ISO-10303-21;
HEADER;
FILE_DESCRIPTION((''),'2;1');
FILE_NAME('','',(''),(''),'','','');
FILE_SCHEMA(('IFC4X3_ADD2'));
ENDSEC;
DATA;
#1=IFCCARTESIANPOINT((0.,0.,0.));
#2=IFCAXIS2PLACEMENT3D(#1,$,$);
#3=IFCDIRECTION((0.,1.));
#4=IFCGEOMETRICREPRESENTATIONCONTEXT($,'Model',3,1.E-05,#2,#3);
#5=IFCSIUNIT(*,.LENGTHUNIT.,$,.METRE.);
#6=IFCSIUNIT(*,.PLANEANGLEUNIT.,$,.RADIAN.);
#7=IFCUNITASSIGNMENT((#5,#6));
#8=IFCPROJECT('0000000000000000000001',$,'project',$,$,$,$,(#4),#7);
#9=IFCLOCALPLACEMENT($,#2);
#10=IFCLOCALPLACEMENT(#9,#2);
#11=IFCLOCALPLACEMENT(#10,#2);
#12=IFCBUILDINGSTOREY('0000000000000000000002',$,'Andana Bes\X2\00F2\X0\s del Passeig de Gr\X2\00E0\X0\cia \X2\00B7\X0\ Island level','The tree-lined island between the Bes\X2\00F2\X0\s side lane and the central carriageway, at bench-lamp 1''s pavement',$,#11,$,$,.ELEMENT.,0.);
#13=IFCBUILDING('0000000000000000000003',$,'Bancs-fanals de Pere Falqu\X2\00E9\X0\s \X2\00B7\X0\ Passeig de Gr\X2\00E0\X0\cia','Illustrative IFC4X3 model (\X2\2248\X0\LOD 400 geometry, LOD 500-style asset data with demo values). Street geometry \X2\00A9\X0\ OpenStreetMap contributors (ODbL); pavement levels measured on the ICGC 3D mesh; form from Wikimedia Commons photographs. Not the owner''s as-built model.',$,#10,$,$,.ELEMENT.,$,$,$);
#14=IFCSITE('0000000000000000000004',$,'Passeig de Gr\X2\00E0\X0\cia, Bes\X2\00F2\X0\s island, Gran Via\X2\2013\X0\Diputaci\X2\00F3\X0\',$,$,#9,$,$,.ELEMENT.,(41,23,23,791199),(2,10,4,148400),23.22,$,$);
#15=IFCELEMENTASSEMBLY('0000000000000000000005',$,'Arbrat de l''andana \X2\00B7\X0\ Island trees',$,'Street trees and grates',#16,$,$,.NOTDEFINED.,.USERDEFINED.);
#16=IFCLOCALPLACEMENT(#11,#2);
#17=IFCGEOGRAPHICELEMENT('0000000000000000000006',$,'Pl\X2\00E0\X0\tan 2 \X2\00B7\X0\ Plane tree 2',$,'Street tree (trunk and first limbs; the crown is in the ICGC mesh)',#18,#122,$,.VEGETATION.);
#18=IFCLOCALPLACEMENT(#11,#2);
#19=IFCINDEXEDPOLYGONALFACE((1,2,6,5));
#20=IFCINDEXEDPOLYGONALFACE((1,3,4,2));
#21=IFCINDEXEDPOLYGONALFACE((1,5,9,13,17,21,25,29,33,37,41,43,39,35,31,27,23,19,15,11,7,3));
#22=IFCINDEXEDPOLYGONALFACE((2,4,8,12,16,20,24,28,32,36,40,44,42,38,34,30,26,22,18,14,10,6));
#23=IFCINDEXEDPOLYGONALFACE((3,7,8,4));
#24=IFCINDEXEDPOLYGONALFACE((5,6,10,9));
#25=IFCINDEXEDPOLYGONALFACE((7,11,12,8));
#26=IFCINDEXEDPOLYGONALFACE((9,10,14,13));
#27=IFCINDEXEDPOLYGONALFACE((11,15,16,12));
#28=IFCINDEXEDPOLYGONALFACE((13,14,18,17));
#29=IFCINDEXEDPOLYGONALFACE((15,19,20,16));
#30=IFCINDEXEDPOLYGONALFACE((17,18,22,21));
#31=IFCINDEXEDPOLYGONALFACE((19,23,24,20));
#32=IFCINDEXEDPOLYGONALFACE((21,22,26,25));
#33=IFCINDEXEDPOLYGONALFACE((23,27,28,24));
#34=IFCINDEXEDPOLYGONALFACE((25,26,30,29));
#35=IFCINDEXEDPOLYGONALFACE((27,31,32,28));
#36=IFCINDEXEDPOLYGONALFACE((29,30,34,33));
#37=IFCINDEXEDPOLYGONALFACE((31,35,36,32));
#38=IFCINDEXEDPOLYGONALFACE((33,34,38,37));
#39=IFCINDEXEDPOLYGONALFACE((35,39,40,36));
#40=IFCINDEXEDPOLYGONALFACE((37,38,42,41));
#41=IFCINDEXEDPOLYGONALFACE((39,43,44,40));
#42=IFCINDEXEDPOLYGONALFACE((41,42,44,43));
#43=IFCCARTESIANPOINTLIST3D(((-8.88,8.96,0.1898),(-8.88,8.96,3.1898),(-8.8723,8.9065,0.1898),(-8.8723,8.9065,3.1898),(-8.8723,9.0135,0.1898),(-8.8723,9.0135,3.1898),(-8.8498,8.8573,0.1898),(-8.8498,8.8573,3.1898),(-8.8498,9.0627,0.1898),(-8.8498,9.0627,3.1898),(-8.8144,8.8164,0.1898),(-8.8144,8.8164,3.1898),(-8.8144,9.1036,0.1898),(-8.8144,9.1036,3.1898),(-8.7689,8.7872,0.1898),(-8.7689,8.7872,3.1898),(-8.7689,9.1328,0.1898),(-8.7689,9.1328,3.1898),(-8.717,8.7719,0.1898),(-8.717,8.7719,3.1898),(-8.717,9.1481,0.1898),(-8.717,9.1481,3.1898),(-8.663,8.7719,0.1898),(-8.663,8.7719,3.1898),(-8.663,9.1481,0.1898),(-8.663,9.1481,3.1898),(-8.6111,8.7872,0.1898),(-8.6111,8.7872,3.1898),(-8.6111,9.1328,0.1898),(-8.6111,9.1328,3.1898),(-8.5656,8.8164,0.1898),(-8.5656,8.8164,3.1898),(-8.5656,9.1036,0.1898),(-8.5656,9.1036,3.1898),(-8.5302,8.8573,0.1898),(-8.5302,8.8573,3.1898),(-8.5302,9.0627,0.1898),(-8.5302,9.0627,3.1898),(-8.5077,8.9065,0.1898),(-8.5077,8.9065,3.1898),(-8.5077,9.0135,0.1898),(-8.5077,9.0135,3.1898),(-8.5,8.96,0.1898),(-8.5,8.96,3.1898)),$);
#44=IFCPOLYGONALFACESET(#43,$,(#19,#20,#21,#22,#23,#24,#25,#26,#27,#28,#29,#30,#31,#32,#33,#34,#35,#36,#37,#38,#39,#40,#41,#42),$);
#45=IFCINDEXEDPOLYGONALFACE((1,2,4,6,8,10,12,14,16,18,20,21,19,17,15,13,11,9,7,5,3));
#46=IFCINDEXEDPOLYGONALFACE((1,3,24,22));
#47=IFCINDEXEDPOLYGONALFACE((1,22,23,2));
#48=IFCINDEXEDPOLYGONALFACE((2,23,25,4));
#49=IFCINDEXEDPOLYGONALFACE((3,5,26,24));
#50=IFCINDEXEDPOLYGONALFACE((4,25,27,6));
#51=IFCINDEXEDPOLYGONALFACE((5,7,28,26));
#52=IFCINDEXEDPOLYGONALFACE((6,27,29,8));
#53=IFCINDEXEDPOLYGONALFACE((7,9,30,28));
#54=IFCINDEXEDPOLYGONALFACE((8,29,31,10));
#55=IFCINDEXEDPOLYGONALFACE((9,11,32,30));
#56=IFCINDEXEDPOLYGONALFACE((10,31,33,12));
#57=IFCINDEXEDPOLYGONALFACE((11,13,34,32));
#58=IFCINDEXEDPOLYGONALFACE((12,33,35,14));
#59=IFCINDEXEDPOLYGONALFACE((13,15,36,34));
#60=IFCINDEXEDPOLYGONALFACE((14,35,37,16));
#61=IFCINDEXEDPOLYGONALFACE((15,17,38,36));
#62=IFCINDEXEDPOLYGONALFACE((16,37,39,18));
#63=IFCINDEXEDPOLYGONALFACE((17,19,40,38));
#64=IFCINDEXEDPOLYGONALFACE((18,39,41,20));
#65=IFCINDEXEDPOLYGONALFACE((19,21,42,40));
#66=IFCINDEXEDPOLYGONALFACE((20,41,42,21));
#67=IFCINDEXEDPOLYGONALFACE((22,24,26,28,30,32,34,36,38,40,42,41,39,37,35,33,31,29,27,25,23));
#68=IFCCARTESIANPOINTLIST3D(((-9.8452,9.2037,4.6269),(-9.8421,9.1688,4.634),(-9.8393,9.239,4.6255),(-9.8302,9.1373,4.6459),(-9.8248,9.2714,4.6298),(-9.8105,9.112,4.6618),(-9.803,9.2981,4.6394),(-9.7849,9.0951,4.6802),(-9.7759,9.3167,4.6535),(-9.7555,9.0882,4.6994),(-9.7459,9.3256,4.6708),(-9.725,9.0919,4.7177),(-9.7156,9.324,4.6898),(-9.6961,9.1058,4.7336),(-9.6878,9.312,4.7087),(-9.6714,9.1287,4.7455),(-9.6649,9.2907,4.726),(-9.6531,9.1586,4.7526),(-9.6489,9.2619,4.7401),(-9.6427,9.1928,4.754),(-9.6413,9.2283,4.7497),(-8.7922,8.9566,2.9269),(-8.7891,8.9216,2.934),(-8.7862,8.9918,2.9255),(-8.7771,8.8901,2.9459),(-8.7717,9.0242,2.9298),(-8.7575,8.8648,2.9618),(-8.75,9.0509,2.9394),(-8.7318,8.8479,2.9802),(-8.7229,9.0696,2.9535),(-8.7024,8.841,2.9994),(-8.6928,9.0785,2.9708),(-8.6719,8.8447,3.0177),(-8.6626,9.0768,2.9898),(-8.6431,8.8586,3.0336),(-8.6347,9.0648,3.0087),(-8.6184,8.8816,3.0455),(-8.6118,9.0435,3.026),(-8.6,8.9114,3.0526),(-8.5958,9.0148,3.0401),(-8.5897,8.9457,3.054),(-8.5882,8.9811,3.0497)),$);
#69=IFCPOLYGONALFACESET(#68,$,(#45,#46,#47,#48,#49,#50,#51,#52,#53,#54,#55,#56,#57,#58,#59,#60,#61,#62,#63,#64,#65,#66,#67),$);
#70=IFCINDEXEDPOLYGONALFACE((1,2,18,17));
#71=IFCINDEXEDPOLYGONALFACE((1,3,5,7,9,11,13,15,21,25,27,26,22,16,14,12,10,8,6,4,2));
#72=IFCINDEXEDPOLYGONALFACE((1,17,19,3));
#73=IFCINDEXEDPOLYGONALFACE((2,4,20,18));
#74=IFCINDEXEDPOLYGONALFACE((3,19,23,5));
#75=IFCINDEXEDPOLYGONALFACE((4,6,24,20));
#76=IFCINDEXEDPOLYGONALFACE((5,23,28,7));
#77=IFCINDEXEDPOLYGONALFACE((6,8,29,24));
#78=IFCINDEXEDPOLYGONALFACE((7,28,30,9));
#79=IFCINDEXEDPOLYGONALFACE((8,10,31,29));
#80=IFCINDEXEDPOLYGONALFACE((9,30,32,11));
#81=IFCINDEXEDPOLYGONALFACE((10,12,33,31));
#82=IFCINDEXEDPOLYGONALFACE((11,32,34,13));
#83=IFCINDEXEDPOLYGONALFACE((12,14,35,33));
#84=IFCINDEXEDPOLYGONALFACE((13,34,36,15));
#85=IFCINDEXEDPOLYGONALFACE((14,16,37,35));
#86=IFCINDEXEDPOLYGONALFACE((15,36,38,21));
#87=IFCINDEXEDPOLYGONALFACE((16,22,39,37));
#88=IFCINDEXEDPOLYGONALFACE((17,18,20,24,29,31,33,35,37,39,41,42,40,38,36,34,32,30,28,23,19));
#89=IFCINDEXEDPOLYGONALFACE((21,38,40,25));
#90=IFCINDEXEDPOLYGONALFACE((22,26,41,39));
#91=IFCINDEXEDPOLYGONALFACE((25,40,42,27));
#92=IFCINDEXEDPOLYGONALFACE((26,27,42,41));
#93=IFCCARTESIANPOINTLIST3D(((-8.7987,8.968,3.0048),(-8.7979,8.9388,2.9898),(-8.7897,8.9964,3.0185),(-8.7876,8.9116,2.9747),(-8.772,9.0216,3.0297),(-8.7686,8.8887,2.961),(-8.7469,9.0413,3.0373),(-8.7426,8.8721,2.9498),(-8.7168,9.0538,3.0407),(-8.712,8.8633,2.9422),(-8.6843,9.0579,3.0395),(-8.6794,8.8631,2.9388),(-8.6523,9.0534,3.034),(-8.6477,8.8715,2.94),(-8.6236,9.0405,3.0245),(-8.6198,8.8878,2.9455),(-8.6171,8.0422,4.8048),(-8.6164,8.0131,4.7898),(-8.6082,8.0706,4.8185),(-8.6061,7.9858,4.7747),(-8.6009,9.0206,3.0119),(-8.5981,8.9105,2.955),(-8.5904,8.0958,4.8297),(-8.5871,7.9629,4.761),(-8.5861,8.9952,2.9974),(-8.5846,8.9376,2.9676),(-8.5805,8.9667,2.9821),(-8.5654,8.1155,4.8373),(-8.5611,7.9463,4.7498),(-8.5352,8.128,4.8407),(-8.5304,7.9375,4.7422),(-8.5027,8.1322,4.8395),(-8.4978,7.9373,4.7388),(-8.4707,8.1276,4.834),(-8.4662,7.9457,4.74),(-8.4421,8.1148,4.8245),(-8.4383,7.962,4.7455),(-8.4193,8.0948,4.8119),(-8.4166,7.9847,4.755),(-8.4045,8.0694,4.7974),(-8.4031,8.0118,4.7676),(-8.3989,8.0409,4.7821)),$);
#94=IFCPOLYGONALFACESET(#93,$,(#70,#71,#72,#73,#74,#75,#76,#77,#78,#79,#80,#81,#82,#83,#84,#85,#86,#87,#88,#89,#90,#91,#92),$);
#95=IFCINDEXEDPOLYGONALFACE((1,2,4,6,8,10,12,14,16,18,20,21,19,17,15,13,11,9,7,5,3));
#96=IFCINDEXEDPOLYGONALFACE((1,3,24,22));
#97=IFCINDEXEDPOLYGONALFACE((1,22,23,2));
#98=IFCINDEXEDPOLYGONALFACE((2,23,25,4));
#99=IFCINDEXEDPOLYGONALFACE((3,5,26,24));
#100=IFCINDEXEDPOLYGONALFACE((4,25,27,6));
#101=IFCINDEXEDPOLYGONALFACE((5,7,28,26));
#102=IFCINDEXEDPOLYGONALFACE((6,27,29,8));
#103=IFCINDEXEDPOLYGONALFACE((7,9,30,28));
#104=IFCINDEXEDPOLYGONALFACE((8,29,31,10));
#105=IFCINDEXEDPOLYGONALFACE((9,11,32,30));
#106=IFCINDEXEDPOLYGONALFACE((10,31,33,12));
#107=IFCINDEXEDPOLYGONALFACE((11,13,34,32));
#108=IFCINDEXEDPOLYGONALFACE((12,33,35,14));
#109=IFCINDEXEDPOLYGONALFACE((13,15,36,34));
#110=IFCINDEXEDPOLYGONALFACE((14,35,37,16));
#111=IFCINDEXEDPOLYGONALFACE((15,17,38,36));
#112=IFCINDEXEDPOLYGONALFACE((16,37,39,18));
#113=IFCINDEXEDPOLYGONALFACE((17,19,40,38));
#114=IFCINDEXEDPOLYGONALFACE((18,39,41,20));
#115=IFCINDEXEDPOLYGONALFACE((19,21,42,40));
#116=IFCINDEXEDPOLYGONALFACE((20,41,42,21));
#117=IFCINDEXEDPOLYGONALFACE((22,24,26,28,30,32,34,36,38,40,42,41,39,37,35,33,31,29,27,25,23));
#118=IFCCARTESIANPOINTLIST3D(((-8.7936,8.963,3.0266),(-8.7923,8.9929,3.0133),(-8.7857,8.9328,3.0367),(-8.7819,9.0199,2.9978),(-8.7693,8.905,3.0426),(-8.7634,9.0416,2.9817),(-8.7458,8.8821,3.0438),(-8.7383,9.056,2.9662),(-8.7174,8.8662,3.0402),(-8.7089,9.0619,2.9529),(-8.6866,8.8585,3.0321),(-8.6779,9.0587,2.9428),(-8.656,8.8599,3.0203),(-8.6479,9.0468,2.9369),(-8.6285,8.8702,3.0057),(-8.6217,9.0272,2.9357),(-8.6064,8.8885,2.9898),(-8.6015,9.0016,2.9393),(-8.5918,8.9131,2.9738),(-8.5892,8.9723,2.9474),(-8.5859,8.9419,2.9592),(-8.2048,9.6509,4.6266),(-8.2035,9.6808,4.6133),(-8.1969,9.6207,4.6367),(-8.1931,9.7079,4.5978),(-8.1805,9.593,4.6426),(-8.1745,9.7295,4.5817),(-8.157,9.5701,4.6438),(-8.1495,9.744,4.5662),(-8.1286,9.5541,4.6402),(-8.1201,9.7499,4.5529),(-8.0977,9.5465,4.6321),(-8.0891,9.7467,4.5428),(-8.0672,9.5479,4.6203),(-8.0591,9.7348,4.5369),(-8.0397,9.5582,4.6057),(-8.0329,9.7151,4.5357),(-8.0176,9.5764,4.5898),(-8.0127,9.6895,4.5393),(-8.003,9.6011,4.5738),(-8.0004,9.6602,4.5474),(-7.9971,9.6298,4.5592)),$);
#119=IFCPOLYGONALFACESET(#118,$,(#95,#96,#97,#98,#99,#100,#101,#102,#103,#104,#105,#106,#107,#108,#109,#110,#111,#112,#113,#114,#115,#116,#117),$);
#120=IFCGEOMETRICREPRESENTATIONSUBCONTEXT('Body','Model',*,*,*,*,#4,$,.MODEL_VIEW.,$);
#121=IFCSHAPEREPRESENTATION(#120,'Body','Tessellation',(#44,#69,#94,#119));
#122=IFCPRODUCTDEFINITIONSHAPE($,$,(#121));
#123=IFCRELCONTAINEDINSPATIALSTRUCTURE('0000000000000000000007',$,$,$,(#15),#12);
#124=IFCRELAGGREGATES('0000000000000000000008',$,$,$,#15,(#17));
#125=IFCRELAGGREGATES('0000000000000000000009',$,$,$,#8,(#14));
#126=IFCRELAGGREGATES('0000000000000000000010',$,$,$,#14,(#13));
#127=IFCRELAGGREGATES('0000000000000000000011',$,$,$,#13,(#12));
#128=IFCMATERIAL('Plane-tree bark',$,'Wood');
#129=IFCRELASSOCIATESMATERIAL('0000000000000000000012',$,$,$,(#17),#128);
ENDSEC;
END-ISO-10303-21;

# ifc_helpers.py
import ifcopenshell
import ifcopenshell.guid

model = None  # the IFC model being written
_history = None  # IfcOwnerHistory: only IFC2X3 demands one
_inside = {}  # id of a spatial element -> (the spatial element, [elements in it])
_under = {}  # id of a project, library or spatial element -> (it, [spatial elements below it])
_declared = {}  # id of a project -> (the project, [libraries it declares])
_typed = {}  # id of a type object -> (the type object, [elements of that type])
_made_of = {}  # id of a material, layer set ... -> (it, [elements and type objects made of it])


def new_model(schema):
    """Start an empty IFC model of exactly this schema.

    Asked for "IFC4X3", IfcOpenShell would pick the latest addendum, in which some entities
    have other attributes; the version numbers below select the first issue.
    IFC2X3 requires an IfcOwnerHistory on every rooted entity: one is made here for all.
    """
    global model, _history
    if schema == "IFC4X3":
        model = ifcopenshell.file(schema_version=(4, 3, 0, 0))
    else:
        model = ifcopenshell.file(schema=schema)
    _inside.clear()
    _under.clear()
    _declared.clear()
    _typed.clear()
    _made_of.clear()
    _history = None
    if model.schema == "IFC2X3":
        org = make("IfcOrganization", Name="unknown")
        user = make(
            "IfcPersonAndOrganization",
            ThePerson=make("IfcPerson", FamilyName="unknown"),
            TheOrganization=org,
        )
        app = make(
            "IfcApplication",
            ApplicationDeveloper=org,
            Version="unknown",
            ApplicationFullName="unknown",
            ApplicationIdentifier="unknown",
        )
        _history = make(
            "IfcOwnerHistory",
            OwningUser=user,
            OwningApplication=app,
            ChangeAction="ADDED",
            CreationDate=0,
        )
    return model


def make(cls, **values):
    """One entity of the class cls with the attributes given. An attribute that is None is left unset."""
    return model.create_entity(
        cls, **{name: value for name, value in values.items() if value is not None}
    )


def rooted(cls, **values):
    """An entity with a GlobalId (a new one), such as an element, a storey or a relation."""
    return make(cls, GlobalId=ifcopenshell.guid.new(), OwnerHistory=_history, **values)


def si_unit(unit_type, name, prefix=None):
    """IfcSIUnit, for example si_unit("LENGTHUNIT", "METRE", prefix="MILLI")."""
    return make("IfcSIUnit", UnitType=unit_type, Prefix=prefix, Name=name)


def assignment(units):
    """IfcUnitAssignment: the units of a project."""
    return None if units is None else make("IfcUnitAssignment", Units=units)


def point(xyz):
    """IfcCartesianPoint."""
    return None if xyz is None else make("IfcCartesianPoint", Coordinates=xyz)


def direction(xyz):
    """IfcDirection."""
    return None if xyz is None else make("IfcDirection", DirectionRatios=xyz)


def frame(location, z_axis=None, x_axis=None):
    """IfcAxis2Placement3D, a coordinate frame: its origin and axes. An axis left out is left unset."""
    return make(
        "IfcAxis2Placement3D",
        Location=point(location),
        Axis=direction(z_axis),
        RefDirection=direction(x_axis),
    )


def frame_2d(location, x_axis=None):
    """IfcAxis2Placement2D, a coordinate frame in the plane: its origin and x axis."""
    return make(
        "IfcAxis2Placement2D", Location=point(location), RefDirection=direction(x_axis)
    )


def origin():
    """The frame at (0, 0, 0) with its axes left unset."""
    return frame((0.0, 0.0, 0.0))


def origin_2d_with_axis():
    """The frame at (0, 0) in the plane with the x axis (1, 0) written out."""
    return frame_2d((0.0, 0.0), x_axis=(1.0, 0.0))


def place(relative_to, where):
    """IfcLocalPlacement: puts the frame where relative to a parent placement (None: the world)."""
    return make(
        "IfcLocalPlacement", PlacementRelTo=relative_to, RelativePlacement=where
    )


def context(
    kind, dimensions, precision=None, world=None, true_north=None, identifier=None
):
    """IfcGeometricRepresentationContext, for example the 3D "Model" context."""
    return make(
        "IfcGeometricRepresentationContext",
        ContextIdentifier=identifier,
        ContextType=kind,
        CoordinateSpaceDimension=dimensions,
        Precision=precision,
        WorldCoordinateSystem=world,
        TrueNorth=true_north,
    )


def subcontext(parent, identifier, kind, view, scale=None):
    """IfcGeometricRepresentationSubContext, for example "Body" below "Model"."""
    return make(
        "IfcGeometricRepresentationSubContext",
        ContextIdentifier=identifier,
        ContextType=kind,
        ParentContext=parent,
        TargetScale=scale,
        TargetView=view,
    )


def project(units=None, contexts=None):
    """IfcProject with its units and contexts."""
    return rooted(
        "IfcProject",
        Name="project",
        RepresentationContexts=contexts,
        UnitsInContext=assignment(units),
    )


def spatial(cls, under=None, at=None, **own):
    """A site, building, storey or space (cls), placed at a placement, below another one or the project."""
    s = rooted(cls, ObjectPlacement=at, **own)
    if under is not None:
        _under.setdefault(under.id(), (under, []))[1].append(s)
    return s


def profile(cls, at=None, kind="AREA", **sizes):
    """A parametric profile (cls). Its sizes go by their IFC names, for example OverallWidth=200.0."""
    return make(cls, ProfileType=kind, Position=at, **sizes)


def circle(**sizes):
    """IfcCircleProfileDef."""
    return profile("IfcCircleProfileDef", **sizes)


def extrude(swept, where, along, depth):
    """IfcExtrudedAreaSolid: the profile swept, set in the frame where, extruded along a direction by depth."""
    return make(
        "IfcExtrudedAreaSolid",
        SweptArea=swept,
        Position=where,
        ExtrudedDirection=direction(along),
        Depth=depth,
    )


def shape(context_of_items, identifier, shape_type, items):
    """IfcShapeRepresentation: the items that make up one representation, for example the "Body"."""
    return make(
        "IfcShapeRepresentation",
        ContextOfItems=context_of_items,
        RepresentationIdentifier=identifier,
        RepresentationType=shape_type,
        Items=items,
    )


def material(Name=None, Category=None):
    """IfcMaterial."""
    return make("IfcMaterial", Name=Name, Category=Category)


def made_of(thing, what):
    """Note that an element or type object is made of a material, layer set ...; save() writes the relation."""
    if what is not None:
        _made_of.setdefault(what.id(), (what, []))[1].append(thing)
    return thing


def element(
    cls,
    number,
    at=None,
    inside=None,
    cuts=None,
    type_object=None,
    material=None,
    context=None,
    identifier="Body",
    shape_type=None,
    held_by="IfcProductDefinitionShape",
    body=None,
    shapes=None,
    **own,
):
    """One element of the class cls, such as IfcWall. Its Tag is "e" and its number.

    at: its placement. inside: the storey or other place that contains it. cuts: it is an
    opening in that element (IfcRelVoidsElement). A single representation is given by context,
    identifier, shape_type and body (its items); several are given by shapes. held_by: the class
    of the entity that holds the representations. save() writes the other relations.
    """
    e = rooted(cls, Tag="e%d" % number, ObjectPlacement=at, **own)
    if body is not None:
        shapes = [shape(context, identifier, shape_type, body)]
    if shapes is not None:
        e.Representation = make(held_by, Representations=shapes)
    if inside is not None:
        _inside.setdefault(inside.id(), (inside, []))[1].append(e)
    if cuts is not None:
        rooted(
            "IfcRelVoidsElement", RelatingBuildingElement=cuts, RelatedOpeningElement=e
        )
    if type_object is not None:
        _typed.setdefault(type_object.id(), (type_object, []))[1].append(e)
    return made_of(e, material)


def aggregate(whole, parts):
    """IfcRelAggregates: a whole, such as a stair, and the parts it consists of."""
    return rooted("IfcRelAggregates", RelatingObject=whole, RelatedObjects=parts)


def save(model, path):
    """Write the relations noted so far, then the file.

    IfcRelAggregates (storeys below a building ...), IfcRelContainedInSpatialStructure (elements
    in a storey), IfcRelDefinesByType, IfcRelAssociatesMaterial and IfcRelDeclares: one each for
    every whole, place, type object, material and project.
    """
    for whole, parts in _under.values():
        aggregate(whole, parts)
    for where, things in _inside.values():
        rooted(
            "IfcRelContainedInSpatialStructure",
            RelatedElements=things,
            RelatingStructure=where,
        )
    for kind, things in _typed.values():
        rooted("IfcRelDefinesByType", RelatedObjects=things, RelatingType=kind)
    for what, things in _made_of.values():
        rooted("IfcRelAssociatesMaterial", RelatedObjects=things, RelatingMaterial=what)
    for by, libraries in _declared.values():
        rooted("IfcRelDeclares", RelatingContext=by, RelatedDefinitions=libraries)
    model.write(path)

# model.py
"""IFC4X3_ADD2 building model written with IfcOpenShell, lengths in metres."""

from ifc_helpers import new_model, si_unit, direction, frame, origin, origin_2d_with_axis, place, context, subcontext, project, spatial, circle, extrude, material, element, aggregate, save


model = new_model("IFC4X3_ADD2")

# Units and contexts
model_context = context("Model", 3, precision=1e-05, world=origin(), true_north=direction((0.0, 1.0)))
body_context = subcontext(model_context, "Body", "Model", "MODEL_VIEW")
ifc_project = project(units=[si_unit("LENGTHUNIT", "METRE"), si_unit("PLANEANGLEUNIT", "RADIAN")], contexts=[model_context])

# Site, building, storey
site_placement = place(None, origin())
site = spatial("IfcSite", under=ifc_project, at=site_placement, Name="Passeig de Gràcia, Besòs island, Gran Via–Diputació", CompositionType="ELEMENT", RefLatitude=(41, 23, 23, 791199), RefLongitude=(2, 10, 4, 148400), RefElevation=23.22)
building_placement = place(site_placement, origin())
building = spatial("IfcBuilding", under=site, at=building_placement, Name="Bancs-fanals de Pere Falqués · Passeig de Gràcia", Description="Illustrative IFC4X3 model (≈LOD 400 geometry, LOD 500-style asset data with demo values). Street geometry © OpenStreetMap contributors (ODbL); pavement levels measured on the ICGC 3D mesh; form from Wikimedia Commons photographs. Not the owner's as-built model.", CompositionType="ELEMENT")
storey_placement = place(building_placement, origin())
storey = spatial("IfcBuildingStorey", under=building, at=storey_placement, Name="Andana Besòs del Passeig de Gràcia · Island level", Description="The tree-lined island between the Besòs side lane and the central carriageway, at bench-lamp 1's pavement", CompositionType="ELEMENT", Elevation=0.0)

# Element assembly
assembly_1_placement = place(building_placement, origin())
assembly_1 = element("IfcElementAssembly", 1, at=assembly_1_placement, inside=storey, Name="Arbrat de l'andana · Island trees", ObjectType="Street trees and grates", AssemblyPlace="NOTDEFINED", PredefinedType="USERDEFINED")

# Geographic element
ifc_material_1 = material(Name="Plane-tree bark", Category="Wood")
geographic_element_1_placement = place(building_placement, origin())
geographic_element_1 = element("IfcGeographicElement", 2, at=geographic_element_1_placement, material=ifc_material_1, Name="Plàtan 2 · Plane tree 2", ObjectType="Street tree (trunk and first limbs; the crown is in the ICGC mesh)", PredefinedType="VEGETATION", context=body_context, shape_type="SweptSolid", body=[
    extrude(circle(Radius=0.19, at=origin_2d_with_axis()), frame((-8.69, 8.96, 0.1898)), (0.0, 0.0, 1.0), 3.0),
    extrude(circle(Radius=0.12, at=origin_2d_with_axis()), frame((-8.69, 8.96, 2.9898), z_axis=(-0.522617, 0.122674, 0.843696), x_axis=(0.22852, 0.973539, 0.0)), (0.0, 0.0, 1.0), 2.0149),
    extrude(circle(Radius=0.11, at=origin_2d_with_axis()), frame((-8.69, 8.96, 2.9898), z_axis=(0.089329, -0.45554, 0.885722), x_axis=(-0.981311, -0.19243, 0.0)), (0.0, 0.0, 1.0), 2.0322),
    extrude(circle(Radius=0.11, at=origin_2d_with_axis()), frame((-8.69, 8.96, 2.9898), z_axis=(0.320275, 0.374202, 0.870285), x_axis=(0.759728, -0.650241, 0.0)), (0.0, 0.0, 1.0), 1.8385),
])
aggregate(assembly_1, [geographic_element_1])

save(model, "model.ifc")
